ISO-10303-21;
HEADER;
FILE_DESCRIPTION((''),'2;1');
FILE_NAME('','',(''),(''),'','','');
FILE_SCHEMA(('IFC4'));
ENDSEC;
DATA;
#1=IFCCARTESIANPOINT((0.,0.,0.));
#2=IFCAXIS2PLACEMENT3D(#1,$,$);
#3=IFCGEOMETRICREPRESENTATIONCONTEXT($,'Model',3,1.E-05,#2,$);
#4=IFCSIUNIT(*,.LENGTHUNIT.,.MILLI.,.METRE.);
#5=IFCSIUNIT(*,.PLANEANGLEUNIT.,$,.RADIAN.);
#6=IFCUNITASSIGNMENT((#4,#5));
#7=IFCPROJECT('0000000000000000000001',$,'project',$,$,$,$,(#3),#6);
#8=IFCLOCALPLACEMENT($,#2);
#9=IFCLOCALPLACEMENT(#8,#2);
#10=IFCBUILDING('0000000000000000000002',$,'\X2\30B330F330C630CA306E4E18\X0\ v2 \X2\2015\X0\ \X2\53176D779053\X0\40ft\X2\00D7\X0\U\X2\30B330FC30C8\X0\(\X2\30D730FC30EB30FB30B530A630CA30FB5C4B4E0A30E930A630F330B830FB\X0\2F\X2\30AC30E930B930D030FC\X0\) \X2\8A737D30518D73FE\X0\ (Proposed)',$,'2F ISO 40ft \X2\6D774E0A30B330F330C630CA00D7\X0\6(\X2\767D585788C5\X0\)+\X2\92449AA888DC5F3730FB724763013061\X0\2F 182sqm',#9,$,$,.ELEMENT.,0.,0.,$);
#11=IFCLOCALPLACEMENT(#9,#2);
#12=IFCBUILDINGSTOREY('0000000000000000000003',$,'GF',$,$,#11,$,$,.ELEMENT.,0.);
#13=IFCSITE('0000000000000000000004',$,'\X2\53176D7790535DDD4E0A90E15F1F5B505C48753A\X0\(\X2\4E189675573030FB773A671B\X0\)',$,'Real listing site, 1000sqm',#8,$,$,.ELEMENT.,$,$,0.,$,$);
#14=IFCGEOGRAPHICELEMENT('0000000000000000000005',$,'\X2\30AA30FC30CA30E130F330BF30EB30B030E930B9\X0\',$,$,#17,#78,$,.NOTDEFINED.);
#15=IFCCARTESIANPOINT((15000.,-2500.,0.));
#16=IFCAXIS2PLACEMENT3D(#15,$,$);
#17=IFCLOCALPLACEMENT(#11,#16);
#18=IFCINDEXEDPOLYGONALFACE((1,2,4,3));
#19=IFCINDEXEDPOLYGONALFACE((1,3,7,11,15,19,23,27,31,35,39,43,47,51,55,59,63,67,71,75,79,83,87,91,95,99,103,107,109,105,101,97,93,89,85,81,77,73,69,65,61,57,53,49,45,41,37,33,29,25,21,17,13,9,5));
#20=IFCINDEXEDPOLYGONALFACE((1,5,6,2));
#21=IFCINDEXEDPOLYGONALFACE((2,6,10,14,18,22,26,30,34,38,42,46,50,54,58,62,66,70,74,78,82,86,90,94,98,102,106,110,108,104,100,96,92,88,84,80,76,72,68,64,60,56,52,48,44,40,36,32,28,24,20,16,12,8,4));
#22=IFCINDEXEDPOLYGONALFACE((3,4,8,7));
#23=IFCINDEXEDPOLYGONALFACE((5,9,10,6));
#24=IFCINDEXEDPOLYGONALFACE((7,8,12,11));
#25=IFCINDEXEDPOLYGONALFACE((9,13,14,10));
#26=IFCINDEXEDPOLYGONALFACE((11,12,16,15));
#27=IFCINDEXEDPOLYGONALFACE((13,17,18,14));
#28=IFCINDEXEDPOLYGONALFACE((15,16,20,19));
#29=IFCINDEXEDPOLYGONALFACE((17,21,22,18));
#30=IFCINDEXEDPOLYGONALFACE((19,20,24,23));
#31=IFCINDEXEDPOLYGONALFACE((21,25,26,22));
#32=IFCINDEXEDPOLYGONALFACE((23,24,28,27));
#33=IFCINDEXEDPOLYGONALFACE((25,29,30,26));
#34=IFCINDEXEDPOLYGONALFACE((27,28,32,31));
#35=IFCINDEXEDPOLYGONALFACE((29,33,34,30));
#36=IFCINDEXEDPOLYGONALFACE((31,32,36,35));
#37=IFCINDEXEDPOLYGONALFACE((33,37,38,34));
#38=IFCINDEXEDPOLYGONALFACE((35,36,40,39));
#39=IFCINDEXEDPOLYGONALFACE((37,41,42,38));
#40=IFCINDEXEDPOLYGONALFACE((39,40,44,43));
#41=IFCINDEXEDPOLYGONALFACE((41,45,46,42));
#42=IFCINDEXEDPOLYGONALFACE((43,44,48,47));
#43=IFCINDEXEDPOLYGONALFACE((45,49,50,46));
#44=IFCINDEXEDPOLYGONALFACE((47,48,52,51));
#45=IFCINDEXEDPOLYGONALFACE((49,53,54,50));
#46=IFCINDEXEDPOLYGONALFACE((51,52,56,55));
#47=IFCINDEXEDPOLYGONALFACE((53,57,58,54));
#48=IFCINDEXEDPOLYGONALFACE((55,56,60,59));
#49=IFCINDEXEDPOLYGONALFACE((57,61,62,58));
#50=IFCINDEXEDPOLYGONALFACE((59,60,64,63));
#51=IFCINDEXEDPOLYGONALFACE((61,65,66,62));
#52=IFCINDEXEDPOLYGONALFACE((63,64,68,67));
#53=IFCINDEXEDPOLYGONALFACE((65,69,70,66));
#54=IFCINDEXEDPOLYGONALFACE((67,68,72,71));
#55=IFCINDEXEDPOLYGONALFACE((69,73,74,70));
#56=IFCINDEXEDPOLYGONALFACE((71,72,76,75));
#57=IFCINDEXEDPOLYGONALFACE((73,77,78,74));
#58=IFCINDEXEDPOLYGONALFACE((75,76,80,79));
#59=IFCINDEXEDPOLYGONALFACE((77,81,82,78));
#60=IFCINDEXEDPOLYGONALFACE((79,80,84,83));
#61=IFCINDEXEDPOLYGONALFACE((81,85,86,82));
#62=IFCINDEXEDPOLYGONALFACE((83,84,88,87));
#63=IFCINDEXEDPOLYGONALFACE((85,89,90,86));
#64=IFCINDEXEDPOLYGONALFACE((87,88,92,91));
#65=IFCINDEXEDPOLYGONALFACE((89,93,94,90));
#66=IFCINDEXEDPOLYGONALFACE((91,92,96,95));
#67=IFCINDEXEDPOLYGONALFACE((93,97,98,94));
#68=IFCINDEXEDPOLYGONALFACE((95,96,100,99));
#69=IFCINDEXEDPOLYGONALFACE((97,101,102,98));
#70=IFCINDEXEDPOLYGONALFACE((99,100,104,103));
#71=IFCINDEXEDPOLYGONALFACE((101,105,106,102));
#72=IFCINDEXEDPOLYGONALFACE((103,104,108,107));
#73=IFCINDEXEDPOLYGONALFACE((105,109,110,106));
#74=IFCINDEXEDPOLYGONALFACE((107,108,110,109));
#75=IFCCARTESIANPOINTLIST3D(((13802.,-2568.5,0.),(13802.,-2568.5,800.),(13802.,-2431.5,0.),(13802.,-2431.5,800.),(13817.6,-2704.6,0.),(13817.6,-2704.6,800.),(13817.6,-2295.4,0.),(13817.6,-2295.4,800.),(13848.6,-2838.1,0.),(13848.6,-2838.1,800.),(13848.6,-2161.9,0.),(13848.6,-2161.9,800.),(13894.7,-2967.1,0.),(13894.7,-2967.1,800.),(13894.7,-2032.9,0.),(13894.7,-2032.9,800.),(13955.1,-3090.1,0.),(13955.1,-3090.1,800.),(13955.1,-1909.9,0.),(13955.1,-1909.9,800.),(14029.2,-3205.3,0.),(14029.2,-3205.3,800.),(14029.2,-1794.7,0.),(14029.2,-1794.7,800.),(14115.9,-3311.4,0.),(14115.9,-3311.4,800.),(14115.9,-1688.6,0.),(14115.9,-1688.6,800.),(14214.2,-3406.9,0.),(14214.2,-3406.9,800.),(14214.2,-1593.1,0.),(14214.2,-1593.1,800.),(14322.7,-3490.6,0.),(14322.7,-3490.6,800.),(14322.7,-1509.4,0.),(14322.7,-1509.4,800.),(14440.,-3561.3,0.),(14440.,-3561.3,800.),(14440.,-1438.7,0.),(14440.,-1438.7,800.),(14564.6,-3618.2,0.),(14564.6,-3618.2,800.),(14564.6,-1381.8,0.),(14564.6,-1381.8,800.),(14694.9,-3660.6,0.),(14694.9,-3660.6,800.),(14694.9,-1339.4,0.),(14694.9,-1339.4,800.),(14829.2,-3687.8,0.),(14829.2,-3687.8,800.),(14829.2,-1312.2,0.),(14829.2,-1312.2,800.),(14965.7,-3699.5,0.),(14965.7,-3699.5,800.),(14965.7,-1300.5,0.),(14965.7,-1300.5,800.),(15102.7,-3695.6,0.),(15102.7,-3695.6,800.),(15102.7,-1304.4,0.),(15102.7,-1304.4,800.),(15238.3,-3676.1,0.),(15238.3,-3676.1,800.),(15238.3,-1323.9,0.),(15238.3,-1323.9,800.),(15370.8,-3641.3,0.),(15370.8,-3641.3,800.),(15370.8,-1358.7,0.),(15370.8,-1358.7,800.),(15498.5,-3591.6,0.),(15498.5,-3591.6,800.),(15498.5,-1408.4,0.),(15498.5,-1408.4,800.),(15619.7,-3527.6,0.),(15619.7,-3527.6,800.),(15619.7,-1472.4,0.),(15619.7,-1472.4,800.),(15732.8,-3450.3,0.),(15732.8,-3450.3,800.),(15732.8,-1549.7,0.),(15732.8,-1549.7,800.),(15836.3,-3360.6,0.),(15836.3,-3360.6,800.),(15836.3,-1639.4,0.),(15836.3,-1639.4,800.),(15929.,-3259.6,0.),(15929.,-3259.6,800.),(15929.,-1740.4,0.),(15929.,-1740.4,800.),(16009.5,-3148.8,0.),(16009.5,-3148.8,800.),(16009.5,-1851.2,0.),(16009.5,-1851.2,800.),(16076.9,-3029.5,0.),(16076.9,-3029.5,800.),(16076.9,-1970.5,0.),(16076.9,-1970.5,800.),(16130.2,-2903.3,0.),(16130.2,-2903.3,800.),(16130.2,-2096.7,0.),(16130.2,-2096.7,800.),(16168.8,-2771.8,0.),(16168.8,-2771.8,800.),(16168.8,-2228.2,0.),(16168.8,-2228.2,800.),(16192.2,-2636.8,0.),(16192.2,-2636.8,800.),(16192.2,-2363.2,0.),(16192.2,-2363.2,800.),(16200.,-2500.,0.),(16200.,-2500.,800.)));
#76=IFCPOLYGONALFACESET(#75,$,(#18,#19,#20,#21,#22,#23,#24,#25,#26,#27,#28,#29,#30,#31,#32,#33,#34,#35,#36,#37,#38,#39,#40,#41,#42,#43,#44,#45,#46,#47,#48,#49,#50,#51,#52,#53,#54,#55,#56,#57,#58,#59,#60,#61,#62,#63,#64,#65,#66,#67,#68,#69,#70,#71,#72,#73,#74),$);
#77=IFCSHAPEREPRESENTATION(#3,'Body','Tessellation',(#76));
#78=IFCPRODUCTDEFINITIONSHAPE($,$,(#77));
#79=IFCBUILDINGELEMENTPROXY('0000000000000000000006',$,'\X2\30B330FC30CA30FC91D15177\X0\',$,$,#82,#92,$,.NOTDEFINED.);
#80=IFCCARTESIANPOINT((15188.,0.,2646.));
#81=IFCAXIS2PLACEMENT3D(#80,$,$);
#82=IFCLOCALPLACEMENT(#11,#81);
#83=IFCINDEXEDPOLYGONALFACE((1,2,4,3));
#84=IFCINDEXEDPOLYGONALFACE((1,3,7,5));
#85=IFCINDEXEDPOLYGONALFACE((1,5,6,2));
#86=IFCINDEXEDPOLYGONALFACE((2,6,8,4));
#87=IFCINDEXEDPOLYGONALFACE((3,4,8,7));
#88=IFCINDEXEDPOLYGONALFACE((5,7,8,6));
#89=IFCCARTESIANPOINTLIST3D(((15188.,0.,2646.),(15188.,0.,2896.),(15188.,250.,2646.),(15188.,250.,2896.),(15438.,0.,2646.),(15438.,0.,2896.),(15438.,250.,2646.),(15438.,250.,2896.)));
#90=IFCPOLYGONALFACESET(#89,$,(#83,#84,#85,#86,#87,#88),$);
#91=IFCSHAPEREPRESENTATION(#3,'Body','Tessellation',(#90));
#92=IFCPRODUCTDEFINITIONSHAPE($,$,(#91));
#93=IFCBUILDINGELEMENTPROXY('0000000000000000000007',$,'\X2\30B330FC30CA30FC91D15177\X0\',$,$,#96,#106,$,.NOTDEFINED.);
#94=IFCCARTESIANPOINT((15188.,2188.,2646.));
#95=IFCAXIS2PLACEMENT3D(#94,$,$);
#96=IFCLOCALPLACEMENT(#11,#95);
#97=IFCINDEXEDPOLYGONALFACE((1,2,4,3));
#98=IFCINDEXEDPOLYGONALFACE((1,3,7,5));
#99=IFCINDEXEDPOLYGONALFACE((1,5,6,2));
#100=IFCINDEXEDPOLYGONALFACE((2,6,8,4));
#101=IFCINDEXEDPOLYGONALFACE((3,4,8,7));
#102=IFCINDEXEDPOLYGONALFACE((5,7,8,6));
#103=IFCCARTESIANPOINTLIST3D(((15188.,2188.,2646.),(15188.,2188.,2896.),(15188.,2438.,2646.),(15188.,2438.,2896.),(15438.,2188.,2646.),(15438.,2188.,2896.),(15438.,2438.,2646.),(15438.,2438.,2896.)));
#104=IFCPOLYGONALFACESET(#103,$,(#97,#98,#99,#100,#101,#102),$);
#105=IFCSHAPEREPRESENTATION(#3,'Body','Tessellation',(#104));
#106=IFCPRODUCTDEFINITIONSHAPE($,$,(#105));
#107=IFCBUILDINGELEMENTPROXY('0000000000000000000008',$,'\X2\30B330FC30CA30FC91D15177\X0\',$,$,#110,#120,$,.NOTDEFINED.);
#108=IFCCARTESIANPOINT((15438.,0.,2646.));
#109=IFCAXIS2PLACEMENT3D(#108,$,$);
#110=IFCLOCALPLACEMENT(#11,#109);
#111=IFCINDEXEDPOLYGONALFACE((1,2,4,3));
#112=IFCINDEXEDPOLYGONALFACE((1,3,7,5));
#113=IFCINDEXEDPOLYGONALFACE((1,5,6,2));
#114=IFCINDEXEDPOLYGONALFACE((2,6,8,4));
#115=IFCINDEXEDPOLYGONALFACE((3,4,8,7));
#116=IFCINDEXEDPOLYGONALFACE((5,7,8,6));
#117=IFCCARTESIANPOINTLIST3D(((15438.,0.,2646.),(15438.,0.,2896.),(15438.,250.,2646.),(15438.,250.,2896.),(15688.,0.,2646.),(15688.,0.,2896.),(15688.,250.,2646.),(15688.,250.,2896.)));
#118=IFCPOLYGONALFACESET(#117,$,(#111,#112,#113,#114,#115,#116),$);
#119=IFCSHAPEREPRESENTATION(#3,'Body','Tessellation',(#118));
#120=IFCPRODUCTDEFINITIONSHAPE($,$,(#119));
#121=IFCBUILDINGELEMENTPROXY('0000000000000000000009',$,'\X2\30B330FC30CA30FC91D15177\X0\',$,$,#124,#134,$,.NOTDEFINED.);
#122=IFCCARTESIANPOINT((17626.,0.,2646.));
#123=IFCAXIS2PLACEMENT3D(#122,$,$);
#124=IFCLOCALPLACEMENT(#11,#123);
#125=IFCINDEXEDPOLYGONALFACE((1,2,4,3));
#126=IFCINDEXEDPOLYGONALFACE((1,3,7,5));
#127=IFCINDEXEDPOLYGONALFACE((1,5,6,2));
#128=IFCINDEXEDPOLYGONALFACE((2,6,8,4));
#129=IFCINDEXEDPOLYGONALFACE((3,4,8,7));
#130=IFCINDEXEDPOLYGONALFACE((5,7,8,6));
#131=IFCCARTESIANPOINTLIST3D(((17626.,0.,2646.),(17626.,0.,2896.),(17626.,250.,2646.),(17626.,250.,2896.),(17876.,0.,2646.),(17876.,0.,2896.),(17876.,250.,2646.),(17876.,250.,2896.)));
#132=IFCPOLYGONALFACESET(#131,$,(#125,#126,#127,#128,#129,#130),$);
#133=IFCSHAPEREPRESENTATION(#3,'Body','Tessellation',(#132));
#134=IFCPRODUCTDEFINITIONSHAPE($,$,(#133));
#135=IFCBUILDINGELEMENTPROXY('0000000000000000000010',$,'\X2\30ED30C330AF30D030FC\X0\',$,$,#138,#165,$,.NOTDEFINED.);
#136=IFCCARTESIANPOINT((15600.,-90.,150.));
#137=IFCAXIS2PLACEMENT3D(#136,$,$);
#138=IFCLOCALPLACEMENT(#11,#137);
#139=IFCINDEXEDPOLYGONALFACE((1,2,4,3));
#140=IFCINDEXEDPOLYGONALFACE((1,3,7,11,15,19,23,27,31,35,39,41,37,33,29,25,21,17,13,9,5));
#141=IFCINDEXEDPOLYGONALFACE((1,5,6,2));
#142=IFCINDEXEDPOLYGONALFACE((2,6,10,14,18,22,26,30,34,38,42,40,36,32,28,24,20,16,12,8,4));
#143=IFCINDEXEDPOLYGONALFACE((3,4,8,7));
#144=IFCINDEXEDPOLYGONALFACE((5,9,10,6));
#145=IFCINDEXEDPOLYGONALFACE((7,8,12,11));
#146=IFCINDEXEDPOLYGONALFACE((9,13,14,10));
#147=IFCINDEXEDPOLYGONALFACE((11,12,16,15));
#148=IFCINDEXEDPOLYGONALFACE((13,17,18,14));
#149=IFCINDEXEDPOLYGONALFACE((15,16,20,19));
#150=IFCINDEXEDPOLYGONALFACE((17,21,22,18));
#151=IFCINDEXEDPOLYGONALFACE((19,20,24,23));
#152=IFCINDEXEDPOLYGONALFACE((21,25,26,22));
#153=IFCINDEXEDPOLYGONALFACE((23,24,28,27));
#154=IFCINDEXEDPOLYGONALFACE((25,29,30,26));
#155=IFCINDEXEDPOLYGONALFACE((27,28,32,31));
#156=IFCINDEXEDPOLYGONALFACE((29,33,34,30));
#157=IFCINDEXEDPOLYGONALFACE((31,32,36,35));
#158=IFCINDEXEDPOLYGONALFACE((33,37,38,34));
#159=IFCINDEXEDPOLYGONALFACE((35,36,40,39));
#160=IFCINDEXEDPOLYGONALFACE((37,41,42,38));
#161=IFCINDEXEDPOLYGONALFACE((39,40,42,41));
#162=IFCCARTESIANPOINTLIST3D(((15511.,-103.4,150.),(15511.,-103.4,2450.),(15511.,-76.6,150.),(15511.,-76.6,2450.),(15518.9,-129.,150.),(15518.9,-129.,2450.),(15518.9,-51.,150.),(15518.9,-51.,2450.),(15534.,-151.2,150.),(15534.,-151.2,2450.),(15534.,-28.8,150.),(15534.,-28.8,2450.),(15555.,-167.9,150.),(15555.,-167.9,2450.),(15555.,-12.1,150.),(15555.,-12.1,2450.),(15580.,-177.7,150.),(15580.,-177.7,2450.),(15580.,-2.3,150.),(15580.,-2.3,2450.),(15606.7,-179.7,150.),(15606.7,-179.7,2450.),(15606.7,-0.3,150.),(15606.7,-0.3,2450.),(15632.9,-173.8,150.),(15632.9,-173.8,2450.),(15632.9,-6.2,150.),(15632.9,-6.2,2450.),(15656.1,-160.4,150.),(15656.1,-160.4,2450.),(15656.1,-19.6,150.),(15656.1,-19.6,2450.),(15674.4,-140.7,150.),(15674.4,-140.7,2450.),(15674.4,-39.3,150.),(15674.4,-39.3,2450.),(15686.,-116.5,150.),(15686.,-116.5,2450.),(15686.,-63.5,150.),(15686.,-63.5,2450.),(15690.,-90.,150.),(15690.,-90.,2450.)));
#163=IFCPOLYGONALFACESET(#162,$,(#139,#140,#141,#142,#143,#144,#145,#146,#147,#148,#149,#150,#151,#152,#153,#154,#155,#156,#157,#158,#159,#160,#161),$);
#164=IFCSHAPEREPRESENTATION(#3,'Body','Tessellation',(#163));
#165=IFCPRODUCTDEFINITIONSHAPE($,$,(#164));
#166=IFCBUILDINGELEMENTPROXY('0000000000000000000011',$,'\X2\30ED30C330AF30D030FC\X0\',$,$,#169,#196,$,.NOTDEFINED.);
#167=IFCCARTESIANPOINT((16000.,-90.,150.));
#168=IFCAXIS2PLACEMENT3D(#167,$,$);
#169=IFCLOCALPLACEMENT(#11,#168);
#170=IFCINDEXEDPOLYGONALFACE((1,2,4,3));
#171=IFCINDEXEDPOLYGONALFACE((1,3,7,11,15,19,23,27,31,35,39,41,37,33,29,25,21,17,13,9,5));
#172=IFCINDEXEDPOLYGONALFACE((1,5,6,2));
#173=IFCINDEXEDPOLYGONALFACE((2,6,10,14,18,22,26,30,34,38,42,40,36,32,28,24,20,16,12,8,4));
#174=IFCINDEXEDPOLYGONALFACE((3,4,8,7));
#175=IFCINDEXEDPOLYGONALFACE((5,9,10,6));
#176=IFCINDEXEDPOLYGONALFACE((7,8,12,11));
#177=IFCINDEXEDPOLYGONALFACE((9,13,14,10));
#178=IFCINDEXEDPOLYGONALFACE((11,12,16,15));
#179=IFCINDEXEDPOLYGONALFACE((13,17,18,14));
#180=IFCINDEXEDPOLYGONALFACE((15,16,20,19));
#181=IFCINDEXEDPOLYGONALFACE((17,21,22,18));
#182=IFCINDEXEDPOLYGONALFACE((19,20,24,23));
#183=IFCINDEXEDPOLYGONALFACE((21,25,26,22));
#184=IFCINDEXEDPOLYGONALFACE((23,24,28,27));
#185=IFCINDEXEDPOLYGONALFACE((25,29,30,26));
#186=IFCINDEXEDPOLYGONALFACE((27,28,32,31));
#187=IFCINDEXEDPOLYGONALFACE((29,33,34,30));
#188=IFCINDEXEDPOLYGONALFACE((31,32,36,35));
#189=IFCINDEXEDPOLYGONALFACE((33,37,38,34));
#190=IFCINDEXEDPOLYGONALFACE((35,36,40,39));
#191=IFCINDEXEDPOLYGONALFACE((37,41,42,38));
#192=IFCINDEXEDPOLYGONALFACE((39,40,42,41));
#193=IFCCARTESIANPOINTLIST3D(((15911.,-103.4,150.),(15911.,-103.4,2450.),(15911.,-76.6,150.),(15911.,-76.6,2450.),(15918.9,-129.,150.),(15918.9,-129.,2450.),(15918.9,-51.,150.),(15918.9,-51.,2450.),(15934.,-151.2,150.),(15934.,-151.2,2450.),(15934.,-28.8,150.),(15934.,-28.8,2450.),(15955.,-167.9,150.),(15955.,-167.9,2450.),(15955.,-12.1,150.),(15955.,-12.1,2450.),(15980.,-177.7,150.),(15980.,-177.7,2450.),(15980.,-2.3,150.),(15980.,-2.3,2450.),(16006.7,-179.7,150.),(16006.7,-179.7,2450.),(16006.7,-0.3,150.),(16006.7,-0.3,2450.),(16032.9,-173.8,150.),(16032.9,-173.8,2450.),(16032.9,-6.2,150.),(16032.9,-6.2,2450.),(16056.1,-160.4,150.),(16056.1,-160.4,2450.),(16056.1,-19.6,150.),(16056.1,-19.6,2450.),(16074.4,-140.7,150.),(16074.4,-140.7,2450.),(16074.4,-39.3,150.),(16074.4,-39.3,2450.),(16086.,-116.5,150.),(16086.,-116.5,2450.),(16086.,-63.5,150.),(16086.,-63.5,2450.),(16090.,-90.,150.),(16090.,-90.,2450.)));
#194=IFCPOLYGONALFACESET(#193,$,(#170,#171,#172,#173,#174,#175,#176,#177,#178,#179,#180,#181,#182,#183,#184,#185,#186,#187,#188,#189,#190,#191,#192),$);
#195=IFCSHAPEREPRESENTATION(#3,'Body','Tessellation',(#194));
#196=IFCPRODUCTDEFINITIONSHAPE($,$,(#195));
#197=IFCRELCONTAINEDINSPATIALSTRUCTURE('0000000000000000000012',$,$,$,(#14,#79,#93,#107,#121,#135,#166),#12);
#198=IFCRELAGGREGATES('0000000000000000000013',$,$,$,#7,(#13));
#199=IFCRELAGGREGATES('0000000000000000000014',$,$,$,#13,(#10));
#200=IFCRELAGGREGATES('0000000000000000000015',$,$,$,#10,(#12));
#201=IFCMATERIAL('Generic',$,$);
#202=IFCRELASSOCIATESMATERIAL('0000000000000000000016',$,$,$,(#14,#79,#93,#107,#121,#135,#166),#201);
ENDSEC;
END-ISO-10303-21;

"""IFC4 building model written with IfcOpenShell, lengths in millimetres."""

from ifc_helpers import new_model, si_unit, frame, frame_2d, origin, origin_2d, place, context, project, spatial, rectangle, circle, extrude, material, element, save


model = new_model("IFC4")

# Units and contexts
model_context = context("Model", 3, precision=1e-05, world=origin())
ifc_project = project(units=[si_unit("LENGTHUNIT", "METRE", prefix="MILLI"), si_unit("PLANEANGLEUNIT", "RADIAN")], contexts=[model_context])

# Site, building, storey
site_placement = place(None, origin())
site = spatial("IfcSite", under=ifc_project, at=site_placement, Name="北海道川上郡弟子屈町(丘陵地・眺望)", ObjectType="Real listing site, 1000sqm", CompositionType="ELEMENT", RefElevation=0.0)
building_placement = place(site_placement, origin())
building = spatial("IfcBuilding", under=site, at=building_placement, Name="コンテナの丘 v2 ― 北海道40ft×Uコート(プール・サウナ・屋上ラウンジ・2Fガラスバー) 詳細再現 (Proposed)", ObjectType="2F ISO 40ft 海上コンテナ×6(白塗装)+鉄骨補強・片持ち2F 182sqm", CompositionType="ELEMENT", ElevationOfRefHeight=0.0, ElevationOfTerrain=0.0)
storey_placement = place(building_placement, origin())
storey = spatial("IfcBuildingStorey", under=building, at=storey_placement, Name="GF", CompositionType="ELEMENT", Elevation=0.0)

# Shared definitions
ifc_material = material(Name="Generic")

# Geographic element
geographic_element_placement = place(storey_placement, frame((15000.0, -2500.0, 0.0)))
element("IfcGeographicElement", 1, at=geographic_element_placement, inside=storey, material=ifc_material, Name="オーナメンタルグラス", PredefinedType="NOTDEFINED", context=model_context, shape_type="SweptSolid", body=[
    extrude(circle(Radius=1200.0, at=origin_2d()), frame((15000.0, -2500.0, 0.0)), (0.0, 0.0, 1.0), 800.0),
])

# Building element proxies
proxy_1_placement = place(storey_placement, frame((15188.0, 0.0, 2646.0)))
element("IfcBuildingElementProxy", 2, at=proxy_1_placement, inside=storey, material=ifc_material, Name="コーナー金具", PredefinedType="NOTDEFINED", context=model_context, shape_type="SweptSolid", body=[
    extrude(rectangle(XDim=250.0, YDim=250.0, at=frame_2d((125.0, 125.0))), frame((15188.0, 0.0, 2646.0)), (0.0, 0.0, 1.0), 250.0),
])
proxy_2_placement = place(storey_placement, frame((15188.0, 2188.0, 2646.0)))
element("IfcBuildingElementProxy", 3, at=proxy_2_placement, inside=storey, material=ifc_material, Name="コーナー金具", PredefinedType="NOTDEFINED", context=model_context, shape_type="SweptSolid", body=[
    extrude(rectangle(XDim=250.0, YDim=250.0, at=frame_2d((125.0, 125.0))), frame((15188.0, 2188.0, 2646.0)), (0.0, 0.0, 1.0), 250.0),
])
proxy_3_placement = place(storey_placement, frame((15438.0, 0.0, 2646.0)))
element("IfcBuildingElementProxy", 4, at=proxy_3_placement, inside=storey, material=ifc_material, Name="コーナー金具", PredefinedType="NOTDEFINED", context=model_context, shape_type="SweptSolid", body=[
    extrude(rectangle(XDim=250.0, YDim=250.0, at=frame_2d((125.0, 125.0))), frame((15438.0, 0.0, 2646.0)), (0.0, 0.0, 1.0), 250.0),
])
proxy_4_placement = place(storey_placement, frame((17626.0, 0.0, 2646.0)))
element("IfcBuildingElementProxy", 5, at=proxy_4_placement, inside=storey, material=ifc_material, Name="コーナー金具", PredefinedType="NOTDEFINED", context=model_context, shape_type="SweptSolid", body=[
    extrude(rectangle(XDim=250.0, YDim=250.0, at=frame_2d((125.0, 125.0))), frame((17626.0, 0.0, 2646.0)), (0.0, 0.0, 1.0), 250.0),
])
proxy_5_placement = place(storey_placement, frame((15600.0, -90.0, 150.0)))
element("IfcBuildingElementProxy", 6, at=proxy_5_placement, inside=storey, material=ifc_material, Name="ロックバー", PredefinedType="NOTDEFINED", context=model_context, shape_type="SweptSolid", body=[
    extrude(circle(Radius=90.0, at=origin_2d()), frame((15600.0, -90.0, 150.0)), (0.0, 0.0, 1.0), 2300.0),
])
proxy_6_placement = place(storey_placement, frame((16000.0, -90.0, 150.0)))
element("IfcBuildingElementProxy", 7, at=proxy_6_placement, inside=storey, material=ifc_material, Name="ロックバー", PredefinedType="NOTDEFINED", context=model_context, shape_type="SweptSolid", body=[
    extrude(circle(Radius=90.0, at=origin_2d()), frame((16000.0, -90.0, 150.0)), (0.0, 0.0, 1.0), 2300.0),
])

save(model, "model.ifc")
